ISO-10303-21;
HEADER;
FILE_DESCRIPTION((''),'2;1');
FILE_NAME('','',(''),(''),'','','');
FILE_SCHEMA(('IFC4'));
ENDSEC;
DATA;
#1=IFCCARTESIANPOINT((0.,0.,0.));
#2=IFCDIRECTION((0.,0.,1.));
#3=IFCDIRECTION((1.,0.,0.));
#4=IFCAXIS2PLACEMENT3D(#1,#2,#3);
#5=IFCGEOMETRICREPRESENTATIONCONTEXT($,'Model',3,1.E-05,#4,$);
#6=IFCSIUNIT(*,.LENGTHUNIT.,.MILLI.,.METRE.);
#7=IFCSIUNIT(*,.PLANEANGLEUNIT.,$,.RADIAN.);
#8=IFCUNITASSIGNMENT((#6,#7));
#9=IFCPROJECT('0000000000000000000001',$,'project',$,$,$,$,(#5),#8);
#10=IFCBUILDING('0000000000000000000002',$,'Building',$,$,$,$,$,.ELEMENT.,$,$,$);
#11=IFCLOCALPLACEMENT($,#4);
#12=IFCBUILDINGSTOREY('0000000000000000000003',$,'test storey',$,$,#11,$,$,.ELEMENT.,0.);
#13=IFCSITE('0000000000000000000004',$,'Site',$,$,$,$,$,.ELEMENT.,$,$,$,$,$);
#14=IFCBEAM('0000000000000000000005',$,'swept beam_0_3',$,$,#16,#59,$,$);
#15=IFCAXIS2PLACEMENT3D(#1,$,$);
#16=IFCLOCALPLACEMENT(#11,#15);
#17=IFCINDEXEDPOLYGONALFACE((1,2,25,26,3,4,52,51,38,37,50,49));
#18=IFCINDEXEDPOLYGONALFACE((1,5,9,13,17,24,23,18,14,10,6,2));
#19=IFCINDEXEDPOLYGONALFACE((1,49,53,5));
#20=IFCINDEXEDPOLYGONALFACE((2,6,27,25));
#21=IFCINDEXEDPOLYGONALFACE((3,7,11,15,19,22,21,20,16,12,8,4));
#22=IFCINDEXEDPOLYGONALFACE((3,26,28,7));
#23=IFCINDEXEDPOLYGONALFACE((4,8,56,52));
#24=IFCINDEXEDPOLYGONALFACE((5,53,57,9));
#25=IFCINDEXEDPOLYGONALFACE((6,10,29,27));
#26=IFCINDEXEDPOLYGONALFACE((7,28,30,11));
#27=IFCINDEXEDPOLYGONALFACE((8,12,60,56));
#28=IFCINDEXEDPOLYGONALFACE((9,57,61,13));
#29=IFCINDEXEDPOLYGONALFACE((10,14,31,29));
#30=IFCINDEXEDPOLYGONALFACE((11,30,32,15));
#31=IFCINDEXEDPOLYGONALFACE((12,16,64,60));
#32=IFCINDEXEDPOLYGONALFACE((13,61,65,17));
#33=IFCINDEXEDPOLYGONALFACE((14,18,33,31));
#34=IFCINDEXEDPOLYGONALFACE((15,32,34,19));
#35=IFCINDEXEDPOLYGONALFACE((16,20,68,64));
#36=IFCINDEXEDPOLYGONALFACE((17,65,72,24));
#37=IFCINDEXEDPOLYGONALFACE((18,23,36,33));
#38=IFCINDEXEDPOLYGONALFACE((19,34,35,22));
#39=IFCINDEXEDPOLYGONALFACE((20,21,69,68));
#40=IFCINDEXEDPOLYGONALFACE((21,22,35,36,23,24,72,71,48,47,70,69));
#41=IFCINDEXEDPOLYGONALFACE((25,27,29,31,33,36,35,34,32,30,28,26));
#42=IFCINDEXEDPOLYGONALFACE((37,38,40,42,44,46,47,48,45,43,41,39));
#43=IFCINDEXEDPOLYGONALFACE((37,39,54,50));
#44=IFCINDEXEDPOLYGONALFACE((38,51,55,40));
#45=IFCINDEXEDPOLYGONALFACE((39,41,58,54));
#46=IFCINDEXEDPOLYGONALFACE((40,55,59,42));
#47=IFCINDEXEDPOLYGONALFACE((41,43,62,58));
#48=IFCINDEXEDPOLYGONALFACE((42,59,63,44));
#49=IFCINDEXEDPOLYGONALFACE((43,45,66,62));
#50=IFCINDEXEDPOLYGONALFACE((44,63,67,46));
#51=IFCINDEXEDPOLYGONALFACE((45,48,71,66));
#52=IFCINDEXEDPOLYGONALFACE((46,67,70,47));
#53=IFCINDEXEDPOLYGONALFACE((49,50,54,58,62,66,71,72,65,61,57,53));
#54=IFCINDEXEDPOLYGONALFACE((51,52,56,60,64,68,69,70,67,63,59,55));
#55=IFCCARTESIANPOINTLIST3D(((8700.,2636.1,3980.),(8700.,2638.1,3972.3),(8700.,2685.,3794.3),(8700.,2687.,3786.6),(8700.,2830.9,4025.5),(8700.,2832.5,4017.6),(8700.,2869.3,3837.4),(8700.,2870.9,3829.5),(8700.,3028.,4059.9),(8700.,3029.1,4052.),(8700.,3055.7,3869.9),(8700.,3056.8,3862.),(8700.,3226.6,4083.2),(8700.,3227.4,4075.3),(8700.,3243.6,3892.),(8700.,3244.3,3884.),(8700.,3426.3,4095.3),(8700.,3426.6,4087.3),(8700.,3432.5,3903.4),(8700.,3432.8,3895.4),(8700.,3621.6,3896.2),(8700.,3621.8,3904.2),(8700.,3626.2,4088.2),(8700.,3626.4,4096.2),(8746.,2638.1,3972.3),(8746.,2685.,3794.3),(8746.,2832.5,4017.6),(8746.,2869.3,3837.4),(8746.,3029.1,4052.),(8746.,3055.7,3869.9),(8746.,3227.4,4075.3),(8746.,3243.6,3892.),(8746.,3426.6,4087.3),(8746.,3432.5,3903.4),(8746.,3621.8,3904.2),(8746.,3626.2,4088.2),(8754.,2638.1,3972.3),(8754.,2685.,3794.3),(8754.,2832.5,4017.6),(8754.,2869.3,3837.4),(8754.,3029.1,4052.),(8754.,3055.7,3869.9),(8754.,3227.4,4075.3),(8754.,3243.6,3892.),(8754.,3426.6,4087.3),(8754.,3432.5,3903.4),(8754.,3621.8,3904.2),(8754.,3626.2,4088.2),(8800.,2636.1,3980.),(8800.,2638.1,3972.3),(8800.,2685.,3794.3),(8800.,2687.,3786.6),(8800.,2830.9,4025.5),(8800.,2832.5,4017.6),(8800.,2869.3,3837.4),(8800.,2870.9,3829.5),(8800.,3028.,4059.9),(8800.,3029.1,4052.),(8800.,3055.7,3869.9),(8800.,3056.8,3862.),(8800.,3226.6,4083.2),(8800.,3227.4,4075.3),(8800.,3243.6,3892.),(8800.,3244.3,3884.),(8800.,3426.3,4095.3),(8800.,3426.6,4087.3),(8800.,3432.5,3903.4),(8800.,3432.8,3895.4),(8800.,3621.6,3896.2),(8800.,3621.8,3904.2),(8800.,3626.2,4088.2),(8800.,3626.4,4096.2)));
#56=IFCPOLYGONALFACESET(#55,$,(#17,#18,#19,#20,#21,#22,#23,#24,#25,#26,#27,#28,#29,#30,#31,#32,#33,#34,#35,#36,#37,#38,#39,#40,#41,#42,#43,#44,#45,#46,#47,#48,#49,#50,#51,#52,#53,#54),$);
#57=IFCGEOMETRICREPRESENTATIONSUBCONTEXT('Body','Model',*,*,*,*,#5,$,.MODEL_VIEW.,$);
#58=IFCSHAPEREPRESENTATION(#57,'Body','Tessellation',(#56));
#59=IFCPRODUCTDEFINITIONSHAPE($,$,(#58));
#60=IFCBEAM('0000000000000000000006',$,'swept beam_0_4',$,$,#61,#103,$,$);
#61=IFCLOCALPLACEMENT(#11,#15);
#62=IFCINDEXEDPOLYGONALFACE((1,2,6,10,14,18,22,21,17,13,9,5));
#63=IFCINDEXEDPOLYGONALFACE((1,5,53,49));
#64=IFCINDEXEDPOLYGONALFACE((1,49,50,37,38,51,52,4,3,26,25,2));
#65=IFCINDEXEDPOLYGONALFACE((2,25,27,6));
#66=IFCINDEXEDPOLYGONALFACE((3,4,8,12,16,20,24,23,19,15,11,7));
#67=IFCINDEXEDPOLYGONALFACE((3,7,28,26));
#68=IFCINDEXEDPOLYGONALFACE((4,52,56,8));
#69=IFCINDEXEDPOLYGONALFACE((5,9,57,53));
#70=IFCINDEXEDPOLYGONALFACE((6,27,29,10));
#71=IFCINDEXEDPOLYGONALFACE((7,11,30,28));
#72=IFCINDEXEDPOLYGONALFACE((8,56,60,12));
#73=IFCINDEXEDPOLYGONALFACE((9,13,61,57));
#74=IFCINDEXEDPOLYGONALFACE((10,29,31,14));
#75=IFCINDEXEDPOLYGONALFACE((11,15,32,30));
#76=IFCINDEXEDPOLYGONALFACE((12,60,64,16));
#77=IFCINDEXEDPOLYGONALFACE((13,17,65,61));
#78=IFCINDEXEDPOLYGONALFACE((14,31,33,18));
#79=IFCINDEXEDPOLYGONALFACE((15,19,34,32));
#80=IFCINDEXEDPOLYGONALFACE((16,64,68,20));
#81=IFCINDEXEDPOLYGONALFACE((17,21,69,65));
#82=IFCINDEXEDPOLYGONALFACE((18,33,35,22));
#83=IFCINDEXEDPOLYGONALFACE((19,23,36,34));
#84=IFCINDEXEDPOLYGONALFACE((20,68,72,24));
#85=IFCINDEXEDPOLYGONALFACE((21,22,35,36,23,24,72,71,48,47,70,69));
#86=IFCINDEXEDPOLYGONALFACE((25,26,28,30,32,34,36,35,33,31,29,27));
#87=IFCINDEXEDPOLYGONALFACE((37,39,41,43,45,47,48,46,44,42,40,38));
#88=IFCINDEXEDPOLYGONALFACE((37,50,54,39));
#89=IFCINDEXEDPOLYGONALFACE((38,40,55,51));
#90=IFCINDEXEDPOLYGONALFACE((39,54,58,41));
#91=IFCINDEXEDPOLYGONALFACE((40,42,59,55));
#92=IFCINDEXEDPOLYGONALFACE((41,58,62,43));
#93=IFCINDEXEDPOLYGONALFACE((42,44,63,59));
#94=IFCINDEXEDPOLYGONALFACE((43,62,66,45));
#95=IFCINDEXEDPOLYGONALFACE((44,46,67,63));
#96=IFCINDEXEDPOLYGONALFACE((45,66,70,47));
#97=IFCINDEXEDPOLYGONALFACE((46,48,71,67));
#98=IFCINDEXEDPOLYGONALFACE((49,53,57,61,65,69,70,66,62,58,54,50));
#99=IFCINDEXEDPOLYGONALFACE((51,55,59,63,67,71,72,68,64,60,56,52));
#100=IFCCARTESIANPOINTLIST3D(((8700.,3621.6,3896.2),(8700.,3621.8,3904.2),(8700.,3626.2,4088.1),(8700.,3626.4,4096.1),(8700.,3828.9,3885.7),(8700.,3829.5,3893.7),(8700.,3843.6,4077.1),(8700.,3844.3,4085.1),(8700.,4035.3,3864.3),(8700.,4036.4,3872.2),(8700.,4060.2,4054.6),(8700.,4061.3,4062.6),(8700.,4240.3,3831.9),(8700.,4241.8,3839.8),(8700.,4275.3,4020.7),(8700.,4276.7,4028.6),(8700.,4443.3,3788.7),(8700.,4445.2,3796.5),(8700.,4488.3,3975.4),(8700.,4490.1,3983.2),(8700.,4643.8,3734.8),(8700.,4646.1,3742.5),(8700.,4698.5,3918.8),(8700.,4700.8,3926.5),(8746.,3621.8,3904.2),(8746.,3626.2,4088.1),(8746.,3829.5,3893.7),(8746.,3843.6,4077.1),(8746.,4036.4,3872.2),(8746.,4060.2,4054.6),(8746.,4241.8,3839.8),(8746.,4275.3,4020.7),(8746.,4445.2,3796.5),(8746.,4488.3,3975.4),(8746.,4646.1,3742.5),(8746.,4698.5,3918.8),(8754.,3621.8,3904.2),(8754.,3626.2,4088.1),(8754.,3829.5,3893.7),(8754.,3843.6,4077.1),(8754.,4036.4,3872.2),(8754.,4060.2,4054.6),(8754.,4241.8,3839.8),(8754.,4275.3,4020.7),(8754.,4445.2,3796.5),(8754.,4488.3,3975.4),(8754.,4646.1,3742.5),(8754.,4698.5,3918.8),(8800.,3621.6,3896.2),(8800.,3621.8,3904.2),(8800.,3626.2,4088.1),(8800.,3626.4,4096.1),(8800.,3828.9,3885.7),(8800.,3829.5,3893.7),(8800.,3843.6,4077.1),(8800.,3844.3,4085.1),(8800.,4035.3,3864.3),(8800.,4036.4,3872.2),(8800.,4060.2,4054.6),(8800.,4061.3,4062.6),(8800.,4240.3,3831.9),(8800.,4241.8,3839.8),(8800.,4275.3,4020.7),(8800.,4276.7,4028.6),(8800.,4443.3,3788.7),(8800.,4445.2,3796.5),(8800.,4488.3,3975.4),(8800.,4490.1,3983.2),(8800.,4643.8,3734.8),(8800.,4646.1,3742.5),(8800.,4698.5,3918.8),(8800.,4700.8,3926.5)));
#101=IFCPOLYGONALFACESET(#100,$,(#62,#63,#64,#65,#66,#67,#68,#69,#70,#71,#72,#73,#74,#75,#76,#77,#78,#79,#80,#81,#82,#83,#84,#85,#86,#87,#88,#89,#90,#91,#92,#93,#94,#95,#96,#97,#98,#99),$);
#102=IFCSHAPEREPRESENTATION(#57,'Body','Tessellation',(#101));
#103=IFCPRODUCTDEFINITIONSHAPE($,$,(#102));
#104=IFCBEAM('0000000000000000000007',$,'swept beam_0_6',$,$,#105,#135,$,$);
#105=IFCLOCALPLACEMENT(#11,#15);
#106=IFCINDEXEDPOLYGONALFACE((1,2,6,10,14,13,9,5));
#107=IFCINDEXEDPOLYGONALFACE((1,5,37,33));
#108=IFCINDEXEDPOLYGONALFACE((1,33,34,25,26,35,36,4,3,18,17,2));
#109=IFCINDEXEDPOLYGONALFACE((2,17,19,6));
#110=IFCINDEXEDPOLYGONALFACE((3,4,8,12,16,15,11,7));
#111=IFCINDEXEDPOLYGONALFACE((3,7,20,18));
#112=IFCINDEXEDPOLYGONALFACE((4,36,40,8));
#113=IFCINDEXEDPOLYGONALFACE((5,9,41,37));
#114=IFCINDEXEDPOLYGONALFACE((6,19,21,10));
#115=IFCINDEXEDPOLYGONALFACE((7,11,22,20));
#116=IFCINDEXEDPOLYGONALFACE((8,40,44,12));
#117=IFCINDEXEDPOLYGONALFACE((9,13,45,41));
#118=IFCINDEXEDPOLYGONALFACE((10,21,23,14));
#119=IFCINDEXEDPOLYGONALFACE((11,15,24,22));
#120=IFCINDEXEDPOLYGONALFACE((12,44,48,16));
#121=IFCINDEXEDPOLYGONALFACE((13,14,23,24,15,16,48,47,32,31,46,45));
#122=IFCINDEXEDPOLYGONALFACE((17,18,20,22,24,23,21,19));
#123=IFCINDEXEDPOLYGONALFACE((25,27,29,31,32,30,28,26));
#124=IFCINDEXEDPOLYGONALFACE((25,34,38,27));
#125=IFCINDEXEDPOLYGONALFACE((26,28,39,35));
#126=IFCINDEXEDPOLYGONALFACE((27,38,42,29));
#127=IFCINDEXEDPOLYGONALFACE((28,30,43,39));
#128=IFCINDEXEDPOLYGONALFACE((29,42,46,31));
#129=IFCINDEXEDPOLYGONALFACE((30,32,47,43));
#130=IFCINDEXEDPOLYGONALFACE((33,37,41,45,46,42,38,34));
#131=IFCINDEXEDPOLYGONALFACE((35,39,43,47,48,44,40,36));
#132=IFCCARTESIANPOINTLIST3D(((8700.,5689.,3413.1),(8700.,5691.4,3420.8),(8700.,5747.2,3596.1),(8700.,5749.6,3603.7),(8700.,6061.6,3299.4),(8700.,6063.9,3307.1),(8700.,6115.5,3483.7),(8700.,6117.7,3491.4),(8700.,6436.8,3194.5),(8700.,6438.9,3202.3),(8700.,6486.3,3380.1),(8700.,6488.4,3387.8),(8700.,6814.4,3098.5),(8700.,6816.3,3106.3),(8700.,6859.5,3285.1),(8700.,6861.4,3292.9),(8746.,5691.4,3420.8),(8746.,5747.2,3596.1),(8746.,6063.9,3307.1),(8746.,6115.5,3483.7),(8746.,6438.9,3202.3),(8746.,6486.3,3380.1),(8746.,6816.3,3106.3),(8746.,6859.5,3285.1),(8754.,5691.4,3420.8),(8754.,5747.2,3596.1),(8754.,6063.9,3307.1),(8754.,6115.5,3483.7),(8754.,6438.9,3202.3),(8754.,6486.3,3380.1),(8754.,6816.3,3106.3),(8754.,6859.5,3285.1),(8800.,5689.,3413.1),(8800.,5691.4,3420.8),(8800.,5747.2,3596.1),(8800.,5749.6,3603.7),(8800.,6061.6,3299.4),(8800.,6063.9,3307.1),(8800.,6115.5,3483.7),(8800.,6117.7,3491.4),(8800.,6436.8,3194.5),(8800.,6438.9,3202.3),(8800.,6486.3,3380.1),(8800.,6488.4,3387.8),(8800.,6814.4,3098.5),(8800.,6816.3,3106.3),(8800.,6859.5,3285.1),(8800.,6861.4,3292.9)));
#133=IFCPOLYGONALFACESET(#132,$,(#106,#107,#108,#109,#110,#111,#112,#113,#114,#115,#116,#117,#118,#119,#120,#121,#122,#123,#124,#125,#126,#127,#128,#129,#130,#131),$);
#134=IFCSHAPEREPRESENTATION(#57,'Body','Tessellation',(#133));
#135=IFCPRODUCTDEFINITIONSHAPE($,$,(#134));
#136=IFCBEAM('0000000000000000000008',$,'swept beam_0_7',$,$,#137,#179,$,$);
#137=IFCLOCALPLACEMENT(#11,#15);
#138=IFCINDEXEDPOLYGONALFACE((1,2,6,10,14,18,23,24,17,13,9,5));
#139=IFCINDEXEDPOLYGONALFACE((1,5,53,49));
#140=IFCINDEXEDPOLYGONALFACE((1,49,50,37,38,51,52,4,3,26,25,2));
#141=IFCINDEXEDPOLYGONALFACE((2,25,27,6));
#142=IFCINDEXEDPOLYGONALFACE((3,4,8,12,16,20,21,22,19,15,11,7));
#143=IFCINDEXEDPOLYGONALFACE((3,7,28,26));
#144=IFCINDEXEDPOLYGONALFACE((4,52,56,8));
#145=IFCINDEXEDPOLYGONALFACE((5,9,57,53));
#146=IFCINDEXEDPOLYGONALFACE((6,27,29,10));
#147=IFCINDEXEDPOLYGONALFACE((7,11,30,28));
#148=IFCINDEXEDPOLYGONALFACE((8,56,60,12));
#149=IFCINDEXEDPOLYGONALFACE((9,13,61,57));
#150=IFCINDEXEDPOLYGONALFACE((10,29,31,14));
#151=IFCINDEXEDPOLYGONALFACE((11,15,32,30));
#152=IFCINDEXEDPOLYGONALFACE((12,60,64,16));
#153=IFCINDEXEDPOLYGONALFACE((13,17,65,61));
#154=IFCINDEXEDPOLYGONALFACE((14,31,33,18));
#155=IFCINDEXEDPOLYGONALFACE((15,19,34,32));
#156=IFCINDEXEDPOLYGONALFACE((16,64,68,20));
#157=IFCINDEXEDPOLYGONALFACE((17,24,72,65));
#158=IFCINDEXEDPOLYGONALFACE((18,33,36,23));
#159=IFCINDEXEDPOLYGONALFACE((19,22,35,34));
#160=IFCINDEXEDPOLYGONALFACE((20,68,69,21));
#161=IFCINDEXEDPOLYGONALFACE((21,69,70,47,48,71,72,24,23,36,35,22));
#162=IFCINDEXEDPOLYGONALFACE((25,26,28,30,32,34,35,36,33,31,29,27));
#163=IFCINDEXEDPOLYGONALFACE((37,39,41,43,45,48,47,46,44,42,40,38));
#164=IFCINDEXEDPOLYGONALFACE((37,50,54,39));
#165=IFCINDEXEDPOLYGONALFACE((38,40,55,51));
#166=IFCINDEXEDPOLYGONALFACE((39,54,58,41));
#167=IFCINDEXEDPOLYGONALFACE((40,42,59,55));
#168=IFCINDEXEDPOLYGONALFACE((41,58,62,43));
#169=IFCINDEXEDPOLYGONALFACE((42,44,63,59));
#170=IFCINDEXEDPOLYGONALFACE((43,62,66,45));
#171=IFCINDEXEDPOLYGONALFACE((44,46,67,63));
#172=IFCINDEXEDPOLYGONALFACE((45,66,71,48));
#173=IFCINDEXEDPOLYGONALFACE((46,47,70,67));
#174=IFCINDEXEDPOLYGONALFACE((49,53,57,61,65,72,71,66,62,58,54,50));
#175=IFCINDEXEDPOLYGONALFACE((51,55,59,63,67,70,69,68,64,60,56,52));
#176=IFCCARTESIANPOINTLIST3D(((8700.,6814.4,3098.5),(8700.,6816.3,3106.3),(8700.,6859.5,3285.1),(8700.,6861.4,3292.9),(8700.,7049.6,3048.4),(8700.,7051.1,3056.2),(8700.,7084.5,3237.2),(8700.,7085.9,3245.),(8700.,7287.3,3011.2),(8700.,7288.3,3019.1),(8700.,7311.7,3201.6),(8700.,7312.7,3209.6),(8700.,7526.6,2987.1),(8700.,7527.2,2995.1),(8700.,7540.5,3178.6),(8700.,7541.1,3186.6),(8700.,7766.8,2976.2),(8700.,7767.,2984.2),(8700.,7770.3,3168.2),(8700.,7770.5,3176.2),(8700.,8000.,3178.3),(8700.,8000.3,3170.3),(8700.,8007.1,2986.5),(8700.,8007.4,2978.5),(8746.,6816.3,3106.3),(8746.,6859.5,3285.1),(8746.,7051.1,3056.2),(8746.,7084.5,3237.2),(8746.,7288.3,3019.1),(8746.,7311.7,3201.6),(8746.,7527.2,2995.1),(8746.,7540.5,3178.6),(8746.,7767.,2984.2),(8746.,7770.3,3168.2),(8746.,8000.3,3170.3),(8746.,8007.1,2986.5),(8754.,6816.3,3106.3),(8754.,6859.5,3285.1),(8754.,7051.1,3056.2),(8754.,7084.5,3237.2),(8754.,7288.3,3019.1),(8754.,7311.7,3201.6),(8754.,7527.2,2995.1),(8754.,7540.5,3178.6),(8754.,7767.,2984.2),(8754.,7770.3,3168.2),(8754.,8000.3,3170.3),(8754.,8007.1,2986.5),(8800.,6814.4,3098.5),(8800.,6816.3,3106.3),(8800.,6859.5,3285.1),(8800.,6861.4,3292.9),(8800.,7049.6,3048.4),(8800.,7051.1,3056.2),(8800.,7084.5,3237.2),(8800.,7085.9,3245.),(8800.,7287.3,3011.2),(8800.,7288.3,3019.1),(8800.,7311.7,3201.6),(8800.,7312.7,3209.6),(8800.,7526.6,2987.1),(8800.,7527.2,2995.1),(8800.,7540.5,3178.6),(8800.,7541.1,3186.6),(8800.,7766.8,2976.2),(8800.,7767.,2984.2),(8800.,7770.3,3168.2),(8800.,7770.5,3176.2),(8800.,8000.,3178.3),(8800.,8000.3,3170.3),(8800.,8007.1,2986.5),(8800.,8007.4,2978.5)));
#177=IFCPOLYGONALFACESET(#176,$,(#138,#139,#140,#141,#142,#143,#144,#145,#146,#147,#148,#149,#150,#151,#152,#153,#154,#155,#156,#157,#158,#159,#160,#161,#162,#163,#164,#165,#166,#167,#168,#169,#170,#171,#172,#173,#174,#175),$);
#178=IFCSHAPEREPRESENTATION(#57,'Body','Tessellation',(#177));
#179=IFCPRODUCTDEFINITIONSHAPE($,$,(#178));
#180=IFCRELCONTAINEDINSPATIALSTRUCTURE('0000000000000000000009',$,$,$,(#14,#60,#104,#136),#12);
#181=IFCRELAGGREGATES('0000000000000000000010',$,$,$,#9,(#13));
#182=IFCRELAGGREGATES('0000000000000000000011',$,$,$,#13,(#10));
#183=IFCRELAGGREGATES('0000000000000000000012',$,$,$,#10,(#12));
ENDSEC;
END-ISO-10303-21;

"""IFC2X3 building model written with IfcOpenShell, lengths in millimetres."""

from ifc_helpers import new_model, entity, si_unit, origin_with_axes, place, context, subcontext, project, spatial, element, save


model = new_model("IFC2X3")

# Units and contexts
model_context = context("Model", 3, precision=1e-05, world=origin_with_axes())
body_context = subcontext(model_context, "Body", "Model", "MODEL_VIEW")
ifc_project = project(units=[si_unit("LENGTHUNIT", "METRE", prefix="MILLI"), si_unit("PLANEANGLEUNIT", "RADIAN")], contexts=[model_context])

# Site, building, storey
site = spatial("IfcSite", under=ifc_project, Name="Site", CompositionType="ELEMENT")
building = spatial("IfcBuilding", under=site, Name="Building", CompositionType="ELEMENT")
storey_placement = place(None, origin_with_axes())
storey = spatial("IfcBuildingStorey", under=building, at=storey_placement, Name="test storey", CompositionType="ELEMENT", Elevation=0.0)

# Beams
beam_1_placement = place(storey_placement, origin_with_axes())
element("IfcBeam", 1, at=beam_1_placement, inside=storey, Name="swept beam_0_3", context=body_context, shape_type="SweptSolid", body=[
    entity("IfcRevolvedAreaSolid", entity("IfcArbitraryClosedProfileDef", "AREA", None, entity("IfcPolyline", [entity("IfcCartesianPoint", [-192.0, -50.0]), entity("IfcCartesianPoint", [-192.0, -4.0]), entity("IfcCartesianPoint", [-8.0, -4.0]), entity("IfcCartesianPoint", [-8.0, -50.0]), entity("IfcCartesianPoint", [0.0, -50.0]), entity("IfcCartesianPoint", [0.0, 50.0]), entity("IfcCartesianPoint", [-8.0, 50.0]), entity("IfcCartesianPoint", [-8.0, 4.0]), entity("IfcCartesianPoint", [-192.0, 4.0]), entity("IfcCartesianPoint", [-192.0, 50.0]), entity("IfcCartesianPoint", [-200.0, 50.0]), entity("IfcCartesianPoint", [-200.0, -50.0]), entity("IfcCartesianPoint", [-192.0, -50.0])])), entity("IfcAxis2Placement3D", entity("IfcCartesianPoint", [8750.0, 2636.1, 3980.0]), entity("IfcDirection", [0.0, -0.967, -0.2547]), entity("IfcDirection", [0.0, -0.2547, 0.967])), entity("IfcAxis1Placement", entity("IfcCartesianPoint", [-3553.6, 0.0, 0.0]), entity("IfcDirection", [0.0, 1.0, 0.0])), 0.281511),
])
beam_2_placement = place(storey_placement, origin_with_axes())
element("IfcBeam", 2, at=beam_2_placement, inside=storey, Name="swept beam_0_4", context=body_context, shape_type="SweptSolid", body=[
    entity("IfcRevolvedAreaSolid", entity("IfcArbitraryClosedProfileDef", "AREA", None, entity("IfcPolyline", [entity("IfcCartesianPoint", [-192.0, -50.0]), entity("IfcCartesianPoint", [-192.0, -4.0]), entity("IfcCartesianPoint", [-8.0, -4.0]), entity("IfcCartesianPoint", [-8.0, -50.0]), entity("IfcCartesianPoint", [0.0, -50.0]), entity("IfcCartesianPoint", [0.0, 50.0]), entity("IfcCartesianPoint", [-8.0, 50.0]), entity("IfcCartesianPoint", [-8.0, 4.0]), entity("IfcCartesianPoint", [-192.0, 4.0]), entity("IfcCartesianPoint", [-192.0, 50.0]), entity("IfcCartesianPoint", [-200.0, 50.0]), entity("IfcCartesianPoint", [-200.0, -50.0]), entity("IfcCartesianPoint", [-192.0, -50.0])])), entity("IfcAxis2Placement3D", entity("IfcCartesianPoint", [8750.0, 3626.4, 4096.1]), entity("IfcDirection", [0.0, -0.9997, 0.024]), entity("IfcDirection", [0.0, 0.024, 0.9997])), entity("IfcAxis1Placement", entity("IfcCartesianPoint", [-4114.2, 0.0, 0.0]), entity("IfcDirection", [0.0, 1.0, 0.0])), 0.265161),
])
beam_3_placement = place(storey_placement, origin_with_axes())
element("IfcBeam", 3, at=beam_3_placement, inside=storey, Name="swept beam_0_6", context=body_context, shape_type="SweptSolid", body=[
    entity("IfcRevolvedAreaSolid", entity("IfcArbitraryClosedProfileDef", "AREA", None, entity("IfcPolyline", [entity("IfcCartesianPoint", [192.0, 50.0]), entity("IfcCartesianPoint", [192.0, 4.0]), entity("IfcCartesianPoint", [8.0, 4.0]), entity("IfcCartesianPoint", [8.0, 50.0]), entity("IfcCartesianPoint", [0.0, 50.0]), entity("IfcCartesianPoint", [0.0, -50.0]), entity("IfcCartesianPoint", [8.0, -50.0]), entity("IfcCartesianPoint", [8.0, -4.0]), entity("IfcCartesianPoint", [192.0, -4.0]), entity("IfcCartesianPoint", [192.0, -50.0]), entity("IfcCartesianPoint", [200.0, -50.0]), entity("IfcCartesianPoint", [200.0, 50.0]), entity("IfcCartesianPoint", [192.0, 50.0])])), entity("IfcAxis2Placement3D", entity("IfcCartesianPoint", [8750.0, 5749.6, 3603.7]), entity("IfcDirection", [0.0, -0.953, 0.3031]), entity("IfcDirection", [0.0, -0.3031, -0.953])), entity("IfcAxis1Placement", entity("IfcCartesianPoint", [-16346.1, 0.0, 0.0]), entity("IfcDirection", [0.0, 1.0, 0.0])), 0.07064),
])
beam_4_placement = place(storey_placement, origin_with_axes())
element("IfcBeam", 4, at=beam_4_placement, inside=storey, Name="swept beam_0_7", context=body_context, shape_type="SweptSolid", body=[
    entity("IfcRevolvedAreaSolid", entity("IfcArbitraryClosedProfileDef", "AREA", None, entity("IfcPolyline", [entity("IfcCartesianPoint", [192.0, 50.0]), entity("IfcCartesianPoint", [192.0, 4.0]), entity("IfcCartesianPoint", [8.0, 4.0]), entity("IfcCartesianPoint", [8.0, 50.0]), entity("IfcCartesianPoint", [0.0, 50.0]), entity("IfcCartesianPoint", [0.0, -50.0]), entity("IfcCartesianPoint", [8.0, -50.0]), entity("IfcCartesianPoint", [8.0, -4.0]), entity("IfcCartesianPoint", [192.0, -4.0]), entity("IfcCartesianPoint", [192.0, -50.0]), entity("IfcCartesianPoint", [200.0, -50.0]), entity("IfcCartesianPoint", [200.0, 50.0]), entity("IfcCartesianPoint", [192.0, 50.0])])), entity("IfcAxis2Placement3D", entity("IfcCartesianPoint", [8750.0, 6861.4, 3292.9]), entity("IfcDirection", [0.0, -0.972, 0.2351]), entity("IfcDirection", [0.0, -0.2351, -0.972])), entity("IfcAxis1Placement", entity("IfcCartesianPoint", [-4188.0, 0.0, 0.0]), entity("IfcDirection", [0.0, 1.0, 0.0])), 0.274099),
])

save(model, "model.ifc")
